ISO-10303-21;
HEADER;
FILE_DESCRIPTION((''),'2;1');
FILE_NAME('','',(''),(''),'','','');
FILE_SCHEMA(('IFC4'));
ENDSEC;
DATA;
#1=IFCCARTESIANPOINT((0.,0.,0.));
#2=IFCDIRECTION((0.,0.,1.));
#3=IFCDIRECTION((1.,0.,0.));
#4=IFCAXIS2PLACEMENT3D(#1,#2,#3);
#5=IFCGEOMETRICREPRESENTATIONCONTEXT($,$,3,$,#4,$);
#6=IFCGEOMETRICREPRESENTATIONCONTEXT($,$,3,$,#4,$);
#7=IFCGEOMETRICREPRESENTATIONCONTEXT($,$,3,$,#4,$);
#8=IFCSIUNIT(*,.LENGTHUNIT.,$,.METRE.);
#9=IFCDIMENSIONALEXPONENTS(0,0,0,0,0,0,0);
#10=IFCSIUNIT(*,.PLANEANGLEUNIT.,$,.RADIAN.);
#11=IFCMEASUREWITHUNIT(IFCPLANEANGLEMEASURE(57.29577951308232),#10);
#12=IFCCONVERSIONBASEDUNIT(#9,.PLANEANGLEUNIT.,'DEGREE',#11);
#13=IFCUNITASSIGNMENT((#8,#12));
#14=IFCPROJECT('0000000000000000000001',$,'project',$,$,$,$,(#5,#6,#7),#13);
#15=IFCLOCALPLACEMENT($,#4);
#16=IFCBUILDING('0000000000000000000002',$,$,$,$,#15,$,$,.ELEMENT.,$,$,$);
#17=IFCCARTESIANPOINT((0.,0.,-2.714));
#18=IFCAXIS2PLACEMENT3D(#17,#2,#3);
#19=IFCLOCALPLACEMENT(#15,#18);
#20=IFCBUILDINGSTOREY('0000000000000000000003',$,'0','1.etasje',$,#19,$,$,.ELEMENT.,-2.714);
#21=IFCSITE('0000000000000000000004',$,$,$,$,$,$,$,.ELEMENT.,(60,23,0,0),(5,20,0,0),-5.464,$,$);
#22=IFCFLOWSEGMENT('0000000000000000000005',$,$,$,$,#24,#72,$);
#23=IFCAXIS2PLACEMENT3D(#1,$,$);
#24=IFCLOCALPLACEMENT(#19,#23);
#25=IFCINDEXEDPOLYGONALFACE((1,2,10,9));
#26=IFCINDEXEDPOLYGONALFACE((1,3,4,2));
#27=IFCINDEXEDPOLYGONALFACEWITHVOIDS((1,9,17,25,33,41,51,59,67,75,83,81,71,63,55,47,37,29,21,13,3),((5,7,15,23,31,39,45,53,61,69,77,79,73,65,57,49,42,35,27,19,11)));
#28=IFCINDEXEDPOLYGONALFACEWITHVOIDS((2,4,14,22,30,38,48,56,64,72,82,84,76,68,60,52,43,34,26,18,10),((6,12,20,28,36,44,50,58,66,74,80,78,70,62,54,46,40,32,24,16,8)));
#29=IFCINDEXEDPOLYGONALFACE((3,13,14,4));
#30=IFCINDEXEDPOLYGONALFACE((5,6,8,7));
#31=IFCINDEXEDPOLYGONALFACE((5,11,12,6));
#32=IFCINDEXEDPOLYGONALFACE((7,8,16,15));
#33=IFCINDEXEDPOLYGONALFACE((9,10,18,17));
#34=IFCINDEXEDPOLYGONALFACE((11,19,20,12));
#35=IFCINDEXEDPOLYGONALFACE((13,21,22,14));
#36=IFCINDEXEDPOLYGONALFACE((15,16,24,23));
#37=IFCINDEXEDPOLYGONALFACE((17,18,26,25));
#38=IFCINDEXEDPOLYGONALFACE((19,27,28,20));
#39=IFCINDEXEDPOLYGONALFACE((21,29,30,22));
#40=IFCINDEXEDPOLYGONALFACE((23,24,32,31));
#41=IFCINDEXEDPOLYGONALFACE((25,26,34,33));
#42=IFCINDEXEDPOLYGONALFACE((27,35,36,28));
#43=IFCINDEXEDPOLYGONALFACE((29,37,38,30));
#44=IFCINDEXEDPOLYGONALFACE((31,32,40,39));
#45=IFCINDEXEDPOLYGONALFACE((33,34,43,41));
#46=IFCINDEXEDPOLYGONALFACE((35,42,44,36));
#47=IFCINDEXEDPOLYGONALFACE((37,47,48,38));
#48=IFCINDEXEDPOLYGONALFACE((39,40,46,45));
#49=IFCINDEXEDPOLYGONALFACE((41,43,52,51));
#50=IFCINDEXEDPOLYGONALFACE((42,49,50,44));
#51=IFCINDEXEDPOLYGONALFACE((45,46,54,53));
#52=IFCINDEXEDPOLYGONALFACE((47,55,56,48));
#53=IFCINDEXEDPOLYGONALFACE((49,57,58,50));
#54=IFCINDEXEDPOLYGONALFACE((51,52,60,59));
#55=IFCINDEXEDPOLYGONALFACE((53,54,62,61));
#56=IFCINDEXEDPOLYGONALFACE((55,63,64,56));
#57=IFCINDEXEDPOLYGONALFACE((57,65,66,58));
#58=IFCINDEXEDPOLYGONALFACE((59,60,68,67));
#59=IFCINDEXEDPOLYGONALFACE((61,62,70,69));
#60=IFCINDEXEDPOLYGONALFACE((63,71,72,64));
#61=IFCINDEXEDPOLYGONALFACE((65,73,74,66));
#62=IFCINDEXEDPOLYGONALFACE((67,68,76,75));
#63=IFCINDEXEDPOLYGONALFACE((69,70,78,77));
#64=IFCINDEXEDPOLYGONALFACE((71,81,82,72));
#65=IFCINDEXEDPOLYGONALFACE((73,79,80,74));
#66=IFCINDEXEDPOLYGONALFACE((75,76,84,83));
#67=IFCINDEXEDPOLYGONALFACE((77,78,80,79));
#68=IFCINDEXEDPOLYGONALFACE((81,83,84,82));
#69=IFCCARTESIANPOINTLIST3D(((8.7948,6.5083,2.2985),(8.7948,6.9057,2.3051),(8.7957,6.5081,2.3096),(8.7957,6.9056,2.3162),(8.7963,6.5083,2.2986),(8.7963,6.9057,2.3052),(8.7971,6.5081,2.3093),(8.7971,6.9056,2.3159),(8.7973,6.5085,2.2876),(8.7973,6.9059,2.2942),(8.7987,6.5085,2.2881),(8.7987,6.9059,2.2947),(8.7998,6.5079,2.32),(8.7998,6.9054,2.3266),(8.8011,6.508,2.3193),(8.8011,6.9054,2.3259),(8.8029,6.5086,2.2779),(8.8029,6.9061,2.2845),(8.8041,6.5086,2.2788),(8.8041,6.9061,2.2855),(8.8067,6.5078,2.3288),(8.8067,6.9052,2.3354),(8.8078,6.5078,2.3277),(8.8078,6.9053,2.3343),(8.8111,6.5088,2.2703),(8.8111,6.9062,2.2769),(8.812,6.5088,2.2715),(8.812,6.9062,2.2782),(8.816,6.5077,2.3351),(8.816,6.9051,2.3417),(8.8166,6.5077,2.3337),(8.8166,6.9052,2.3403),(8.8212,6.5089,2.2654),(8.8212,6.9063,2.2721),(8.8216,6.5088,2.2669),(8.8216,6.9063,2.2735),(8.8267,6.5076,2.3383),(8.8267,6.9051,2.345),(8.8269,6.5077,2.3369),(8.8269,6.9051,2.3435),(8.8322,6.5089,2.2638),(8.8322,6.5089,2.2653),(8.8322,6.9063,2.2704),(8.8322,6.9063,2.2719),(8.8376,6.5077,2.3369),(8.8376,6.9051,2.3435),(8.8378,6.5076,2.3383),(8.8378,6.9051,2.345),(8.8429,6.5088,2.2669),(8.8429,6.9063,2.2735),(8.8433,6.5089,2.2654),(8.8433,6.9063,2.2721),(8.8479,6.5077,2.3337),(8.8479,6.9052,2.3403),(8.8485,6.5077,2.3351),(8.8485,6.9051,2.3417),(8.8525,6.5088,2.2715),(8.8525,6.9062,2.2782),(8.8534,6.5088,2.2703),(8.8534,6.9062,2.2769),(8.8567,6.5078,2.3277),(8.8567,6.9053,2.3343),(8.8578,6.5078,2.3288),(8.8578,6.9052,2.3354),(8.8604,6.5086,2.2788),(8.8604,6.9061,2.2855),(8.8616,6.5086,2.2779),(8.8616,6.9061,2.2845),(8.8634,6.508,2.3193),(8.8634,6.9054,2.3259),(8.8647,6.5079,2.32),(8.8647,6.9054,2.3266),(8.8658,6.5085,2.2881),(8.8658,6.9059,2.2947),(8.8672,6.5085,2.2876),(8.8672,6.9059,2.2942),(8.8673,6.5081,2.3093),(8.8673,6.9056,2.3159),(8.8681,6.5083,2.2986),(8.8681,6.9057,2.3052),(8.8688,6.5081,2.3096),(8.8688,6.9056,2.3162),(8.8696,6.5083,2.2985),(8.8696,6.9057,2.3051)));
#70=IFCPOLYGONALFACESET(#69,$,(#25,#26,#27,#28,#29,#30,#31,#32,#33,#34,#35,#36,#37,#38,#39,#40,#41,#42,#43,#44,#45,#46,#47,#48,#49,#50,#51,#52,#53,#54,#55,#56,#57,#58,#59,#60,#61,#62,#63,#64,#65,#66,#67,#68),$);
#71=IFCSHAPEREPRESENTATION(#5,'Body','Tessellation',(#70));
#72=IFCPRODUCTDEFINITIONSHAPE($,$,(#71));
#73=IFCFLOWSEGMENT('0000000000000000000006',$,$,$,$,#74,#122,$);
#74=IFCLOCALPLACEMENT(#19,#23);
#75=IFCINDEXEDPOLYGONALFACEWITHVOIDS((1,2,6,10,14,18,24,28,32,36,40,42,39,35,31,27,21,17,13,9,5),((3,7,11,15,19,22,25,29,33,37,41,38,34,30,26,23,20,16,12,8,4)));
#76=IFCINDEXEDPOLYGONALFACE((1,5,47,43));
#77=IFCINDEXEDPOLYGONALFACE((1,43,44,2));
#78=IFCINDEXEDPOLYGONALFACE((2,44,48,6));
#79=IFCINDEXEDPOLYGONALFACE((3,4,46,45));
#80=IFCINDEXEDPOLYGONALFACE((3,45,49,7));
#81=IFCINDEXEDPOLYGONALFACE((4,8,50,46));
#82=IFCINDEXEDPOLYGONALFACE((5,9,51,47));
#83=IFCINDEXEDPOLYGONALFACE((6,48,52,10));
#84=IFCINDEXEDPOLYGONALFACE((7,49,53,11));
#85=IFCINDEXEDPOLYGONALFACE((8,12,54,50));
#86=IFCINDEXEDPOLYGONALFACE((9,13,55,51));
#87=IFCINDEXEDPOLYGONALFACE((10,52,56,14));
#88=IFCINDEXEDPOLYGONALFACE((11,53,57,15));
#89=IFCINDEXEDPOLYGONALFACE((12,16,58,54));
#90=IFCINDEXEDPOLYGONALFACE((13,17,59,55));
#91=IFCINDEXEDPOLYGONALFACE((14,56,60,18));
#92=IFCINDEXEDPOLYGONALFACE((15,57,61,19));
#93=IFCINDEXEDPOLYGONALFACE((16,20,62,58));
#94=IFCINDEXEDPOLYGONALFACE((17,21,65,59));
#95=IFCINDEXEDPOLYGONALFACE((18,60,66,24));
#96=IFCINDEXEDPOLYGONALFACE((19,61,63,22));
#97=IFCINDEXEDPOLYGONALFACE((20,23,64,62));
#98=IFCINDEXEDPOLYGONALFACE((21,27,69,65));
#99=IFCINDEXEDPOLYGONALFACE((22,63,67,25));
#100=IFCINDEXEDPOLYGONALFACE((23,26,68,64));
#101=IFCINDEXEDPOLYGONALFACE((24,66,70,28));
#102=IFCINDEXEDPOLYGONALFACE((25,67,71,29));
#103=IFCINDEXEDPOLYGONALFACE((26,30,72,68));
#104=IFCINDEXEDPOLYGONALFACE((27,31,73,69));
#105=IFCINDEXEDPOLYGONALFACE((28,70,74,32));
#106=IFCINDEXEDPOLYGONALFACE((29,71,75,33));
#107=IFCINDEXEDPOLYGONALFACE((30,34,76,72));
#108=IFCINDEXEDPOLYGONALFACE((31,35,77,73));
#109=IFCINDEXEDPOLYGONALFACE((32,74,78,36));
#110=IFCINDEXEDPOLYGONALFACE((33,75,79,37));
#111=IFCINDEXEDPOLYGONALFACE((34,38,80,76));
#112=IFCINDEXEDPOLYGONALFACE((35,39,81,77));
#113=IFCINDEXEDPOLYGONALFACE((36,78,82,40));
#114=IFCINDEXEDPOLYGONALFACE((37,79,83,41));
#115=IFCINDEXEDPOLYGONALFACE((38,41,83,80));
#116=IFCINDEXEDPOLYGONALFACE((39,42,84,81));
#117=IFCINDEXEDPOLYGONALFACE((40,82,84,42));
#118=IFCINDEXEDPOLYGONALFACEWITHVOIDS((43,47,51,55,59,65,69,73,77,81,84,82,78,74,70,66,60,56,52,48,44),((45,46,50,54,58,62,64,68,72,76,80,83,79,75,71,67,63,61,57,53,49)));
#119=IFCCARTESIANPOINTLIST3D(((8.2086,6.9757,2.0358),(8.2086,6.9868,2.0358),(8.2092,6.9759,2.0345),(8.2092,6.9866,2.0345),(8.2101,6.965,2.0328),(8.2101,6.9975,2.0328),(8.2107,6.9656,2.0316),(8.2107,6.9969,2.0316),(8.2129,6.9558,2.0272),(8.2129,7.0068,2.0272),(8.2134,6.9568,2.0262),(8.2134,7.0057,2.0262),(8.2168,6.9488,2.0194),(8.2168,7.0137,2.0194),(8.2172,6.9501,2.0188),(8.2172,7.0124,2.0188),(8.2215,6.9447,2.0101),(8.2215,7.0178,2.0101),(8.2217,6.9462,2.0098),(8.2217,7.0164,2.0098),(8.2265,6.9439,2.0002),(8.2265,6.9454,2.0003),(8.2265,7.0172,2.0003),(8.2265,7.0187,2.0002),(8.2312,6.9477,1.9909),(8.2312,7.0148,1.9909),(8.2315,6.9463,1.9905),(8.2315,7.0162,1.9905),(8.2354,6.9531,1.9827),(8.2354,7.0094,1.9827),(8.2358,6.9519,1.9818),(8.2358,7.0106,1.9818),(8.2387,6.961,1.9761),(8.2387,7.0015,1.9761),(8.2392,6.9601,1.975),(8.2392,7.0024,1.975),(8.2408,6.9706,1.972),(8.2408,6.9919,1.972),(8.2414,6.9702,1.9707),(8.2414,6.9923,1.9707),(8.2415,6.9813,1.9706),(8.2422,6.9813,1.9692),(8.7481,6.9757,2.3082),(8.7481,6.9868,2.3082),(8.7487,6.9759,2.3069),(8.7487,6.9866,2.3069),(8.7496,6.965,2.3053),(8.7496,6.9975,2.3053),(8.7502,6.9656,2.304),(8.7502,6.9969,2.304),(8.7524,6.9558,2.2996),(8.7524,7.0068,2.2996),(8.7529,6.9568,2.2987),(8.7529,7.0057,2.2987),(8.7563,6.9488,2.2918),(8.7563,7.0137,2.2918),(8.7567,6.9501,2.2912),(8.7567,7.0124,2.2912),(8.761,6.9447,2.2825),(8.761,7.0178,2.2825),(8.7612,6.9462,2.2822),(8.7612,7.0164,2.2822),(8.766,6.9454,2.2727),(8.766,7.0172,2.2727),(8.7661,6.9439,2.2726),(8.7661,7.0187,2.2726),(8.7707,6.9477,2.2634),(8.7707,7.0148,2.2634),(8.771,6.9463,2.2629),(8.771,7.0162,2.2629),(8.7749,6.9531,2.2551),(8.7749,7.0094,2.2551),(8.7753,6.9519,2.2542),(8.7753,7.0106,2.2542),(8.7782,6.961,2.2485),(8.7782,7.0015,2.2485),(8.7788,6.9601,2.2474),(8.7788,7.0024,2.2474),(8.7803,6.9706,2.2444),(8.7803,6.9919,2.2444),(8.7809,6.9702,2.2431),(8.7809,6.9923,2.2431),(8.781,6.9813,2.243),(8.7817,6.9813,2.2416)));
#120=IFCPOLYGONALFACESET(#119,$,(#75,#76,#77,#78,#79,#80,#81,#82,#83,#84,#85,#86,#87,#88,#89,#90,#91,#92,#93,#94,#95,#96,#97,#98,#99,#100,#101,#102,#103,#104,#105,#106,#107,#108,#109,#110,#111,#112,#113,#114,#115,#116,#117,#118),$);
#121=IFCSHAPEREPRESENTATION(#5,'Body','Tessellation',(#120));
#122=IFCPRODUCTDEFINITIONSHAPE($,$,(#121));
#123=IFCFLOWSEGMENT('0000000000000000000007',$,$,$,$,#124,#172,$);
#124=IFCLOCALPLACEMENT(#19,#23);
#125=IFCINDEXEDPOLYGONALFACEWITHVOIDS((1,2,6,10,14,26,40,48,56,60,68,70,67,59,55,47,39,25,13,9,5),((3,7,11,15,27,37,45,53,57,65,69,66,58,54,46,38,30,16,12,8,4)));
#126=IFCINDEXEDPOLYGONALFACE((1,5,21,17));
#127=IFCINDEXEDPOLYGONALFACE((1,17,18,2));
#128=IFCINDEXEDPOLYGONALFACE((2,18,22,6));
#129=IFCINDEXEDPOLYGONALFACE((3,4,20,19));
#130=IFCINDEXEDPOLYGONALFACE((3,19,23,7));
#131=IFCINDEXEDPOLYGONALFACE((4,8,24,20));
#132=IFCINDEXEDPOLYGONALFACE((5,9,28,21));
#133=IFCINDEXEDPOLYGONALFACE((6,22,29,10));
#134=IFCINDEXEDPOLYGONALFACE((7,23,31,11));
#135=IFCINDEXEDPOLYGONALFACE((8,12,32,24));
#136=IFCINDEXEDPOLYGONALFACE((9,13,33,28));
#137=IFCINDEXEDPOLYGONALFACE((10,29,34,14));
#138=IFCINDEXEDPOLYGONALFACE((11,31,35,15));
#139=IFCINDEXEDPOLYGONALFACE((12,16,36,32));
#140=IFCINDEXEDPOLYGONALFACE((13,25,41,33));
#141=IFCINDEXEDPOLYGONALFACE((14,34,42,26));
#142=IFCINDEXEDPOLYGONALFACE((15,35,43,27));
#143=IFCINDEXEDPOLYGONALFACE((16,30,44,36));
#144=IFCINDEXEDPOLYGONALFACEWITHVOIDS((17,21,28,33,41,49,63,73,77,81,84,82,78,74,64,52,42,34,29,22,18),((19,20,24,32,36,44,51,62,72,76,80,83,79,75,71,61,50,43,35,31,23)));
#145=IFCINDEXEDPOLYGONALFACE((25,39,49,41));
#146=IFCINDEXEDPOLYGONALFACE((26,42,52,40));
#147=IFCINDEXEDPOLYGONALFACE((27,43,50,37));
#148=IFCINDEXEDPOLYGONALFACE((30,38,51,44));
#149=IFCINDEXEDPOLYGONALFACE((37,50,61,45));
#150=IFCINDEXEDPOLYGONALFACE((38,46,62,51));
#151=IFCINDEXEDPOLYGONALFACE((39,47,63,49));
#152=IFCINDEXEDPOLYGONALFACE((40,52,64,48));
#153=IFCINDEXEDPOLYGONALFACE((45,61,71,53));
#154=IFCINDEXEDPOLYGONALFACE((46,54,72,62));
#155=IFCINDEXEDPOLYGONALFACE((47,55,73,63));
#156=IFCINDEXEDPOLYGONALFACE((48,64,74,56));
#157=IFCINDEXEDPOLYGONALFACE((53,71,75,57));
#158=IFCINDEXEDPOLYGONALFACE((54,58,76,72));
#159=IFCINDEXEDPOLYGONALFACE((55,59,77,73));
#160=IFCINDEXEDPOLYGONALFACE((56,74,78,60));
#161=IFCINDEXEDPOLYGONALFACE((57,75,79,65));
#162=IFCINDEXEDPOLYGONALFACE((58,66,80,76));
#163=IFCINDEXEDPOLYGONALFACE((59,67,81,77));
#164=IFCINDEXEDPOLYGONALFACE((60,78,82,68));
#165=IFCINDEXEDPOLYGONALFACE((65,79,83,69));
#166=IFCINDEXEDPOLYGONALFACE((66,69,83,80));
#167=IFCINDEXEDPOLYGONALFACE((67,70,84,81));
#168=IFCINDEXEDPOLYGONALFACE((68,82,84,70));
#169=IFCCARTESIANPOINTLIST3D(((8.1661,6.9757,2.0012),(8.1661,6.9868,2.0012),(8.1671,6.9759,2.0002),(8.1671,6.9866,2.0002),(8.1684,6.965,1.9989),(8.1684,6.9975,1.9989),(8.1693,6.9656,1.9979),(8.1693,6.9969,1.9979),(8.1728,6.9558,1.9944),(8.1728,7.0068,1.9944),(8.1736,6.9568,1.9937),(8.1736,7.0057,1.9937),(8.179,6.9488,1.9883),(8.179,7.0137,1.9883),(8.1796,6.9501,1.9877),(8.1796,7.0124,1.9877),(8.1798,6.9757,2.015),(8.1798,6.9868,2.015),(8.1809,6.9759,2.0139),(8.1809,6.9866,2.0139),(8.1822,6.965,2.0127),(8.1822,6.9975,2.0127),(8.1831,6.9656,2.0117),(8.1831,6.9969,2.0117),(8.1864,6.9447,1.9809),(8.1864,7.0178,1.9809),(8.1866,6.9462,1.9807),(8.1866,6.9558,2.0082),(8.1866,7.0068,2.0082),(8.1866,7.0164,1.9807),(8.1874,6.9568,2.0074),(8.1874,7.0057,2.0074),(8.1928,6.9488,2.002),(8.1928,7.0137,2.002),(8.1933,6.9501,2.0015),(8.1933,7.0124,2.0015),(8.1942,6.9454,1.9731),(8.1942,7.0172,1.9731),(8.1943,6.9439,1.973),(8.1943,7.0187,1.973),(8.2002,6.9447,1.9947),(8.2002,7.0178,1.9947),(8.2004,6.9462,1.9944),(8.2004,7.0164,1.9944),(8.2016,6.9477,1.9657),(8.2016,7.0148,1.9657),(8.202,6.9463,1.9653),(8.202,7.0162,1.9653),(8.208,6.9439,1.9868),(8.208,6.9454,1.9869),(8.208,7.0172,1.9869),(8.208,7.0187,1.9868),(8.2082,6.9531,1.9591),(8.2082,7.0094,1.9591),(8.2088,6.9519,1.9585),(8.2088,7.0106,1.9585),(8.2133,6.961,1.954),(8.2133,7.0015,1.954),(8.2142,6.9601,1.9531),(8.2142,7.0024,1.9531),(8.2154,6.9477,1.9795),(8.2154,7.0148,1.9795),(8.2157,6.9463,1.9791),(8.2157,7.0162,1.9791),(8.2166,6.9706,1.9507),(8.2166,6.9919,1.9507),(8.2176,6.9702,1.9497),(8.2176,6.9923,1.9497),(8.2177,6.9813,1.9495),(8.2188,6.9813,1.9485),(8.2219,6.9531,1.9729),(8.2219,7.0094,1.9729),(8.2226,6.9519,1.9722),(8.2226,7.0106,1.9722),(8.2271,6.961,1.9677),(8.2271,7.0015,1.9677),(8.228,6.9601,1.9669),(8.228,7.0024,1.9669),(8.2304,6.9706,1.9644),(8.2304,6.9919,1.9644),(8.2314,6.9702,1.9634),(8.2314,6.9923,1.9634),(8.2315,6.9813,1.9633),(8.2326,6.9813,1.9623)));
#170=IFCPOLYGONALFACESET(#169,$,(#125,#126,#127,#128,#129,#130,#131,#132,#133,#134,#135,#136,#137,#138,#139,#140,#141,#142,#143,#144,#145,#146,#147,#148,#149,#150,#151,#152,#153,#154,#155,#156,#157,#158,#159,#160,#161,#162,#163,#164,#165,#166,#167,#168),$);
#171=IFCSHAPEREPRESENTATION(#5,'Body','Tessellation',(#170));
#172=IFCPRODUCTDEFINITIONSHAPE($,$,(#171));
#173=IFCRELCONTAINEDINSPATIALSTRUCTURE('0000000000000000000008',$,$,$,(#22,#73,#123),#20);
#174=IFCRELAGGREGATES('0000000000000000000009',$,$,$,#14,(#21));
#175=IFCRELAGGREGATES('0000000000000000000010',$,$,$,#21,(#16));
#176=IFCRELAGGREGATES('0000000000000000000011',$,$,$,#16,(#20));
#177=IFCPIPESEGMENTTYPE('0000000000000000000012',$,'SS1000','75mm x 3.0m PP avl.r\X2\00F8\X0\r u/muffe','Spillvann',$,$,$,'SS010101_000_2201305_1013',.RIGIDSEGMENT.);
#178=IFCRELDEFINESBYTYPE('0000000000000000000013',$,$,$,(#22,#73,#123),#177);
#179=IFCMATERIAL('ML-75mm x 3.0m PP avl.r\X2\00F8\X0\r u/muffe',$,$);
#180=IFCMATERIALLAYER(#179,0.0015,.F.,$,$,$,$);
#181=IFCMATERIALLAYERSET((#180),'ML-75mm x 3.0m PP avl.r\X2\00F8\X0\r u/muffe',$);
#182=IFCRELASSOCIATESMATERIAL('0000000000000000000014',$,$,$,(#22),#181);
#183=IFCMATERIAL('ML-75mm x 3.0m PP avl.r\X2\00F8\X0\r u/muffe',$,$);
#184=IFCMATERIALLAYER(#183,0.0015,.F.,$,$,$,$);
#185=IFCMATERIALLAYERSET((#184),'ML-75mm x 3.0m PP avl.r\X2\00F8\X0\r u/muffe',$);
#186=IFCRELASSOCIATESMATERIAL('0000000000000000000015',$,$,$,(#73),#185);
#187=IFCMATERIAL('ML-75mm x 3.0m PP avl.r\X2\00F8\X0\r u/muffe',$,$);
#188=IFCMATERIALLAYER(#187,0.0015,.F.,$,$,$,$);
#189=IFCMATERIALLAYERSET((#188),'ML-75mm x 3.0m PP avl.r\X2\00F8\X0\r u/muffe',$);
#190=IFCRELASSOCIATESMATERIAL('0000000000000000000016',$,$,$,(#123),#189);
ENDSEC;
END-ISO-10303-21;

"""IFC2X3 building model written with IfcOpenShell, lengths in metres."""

from ifc_helpers import new_model, entity, si_unit, converted_unit, frame, origin_with_axes, origin_2d_with_axis, place, context, project, spatial, hollow_circle, extrude, material, layer, layer_set, layer_usage, type_object, element, save


model = new_model("IFC2X3")

# Units and contexts
context_of_model_1 = context(None, 3, world=origin_with_axes())
context_of_model_2 = context(None, 3, world=origin_with_axes())
context_of_model_3 = context(None, 3, world=origin_with_axes())
ifc_project = project(units=[si_unit("LENGTHUNIT", "METRE"), converted_unit("PLANEANGLEUNIT", "DEGREE", entity("IfcPlaneAngleMeasure", 57.29577951308232), si_unit("PLANEANGLEUNIT", "RADIAN"), dimensions=[0, 0, 0, 0, 0, 0, 0])], contexts=[context_of_model_1, context_of_model_2, context_of_model_3])

# Site, building, storey
site = spatial("IfcSite", under=ifc_project, CompositionType="ELEMENT", RefLatitude=(60, 23, 0, 0), RefLongitude=(5, 20, 0, 0), RefElevation=-5.464)
building_placement = place(None, origin_with_axes())
building = spatial("IfcBuilding", under=site, at=building_placement, CompositionType="ELEMENT")
storey_placement = place(building_placement, frame((0.0, 0.0, -2.714), z_axis=(0.0, 0.0, 1.0), x_axis=(1.0, 0.0, 0.0)))
storey = spatial("IfcBuildingStorey", under=building, at=storey_placement, Name="0", Description="1.etasje", CompositionType="ELEMENT", Elevation=-2.714)

# Flow segments
pipe_segment_type_1 = type_object("IfcPipeSegmentType", Name="SS1000", Description="75mm x 3.0m PP avl.rør u/muffe", ApplicableOccurrence="Spillvann", ElementType="SS010101_000_2201305_1013", PredefinedType="RIGIDSEGMENT")
ifc_material_1 = material(Name="ML-75mm x 3.0m PP avl.rør u/muffe")
ifc_layer_1 = layer(ifc_material_1, 0.0015, ventilated=False)
ifc_layer_set_1 = layer_set([ifc_layer_1], Name="ML-75mm x 3.0m PP avl.rør u/muffe")
ifc_layer_usage_1 = layer_usage(ifc_layer_set_1, "AXIS2", "POSITIVE", 0.0)
flow_segment_1_placement = place(storey_placement, frame((8.8322, 6.5083, 2.3013), z_axis=(0.0, 0.999861, 0.016665), x_axis=(0.0, 0.016665, -0.999861)))
element("IfcFlowSegment", 1, at=flow_segment_1_placement, inside=storey, type_object=pipe_segment_type_1, material=ifc_layer_usage_1, context=context_of_model_1, shape_type="SweptSolid", body=[
    extrude(hollow_circle(Radius=0.0375, WallThickness=0.0015, at=origin_2d_with_axis()), origin_with_axes(), (0.0, 0.0, 1.0), 0.3975),
])
ifc_material_2 = material(Name="ML-75mm x 3.0m PP avl.rør u/muffe")
ifc_layer_2 = layer(ifc_material_2, 0.0015, ventilated=False)
ifc_layer_set_2 = layer_set([ifc_layer_2], Name="ML-75mm x 3.0m PP avl.rør u/muffe")
ifc_layer_usage_2 = layer_usage(ifc_layer_set_2, "AXIS2", "POSITIVE", 0.0)
flow_segment_2_placement = place(storey_placement, frame((8.7648, 6.9813, 2.2751), z_axis=(-0.892665, 0.0, -0.45072), x_axis=(0.45072, 0.0, -0.892665)))
element("IfcFlowSegment", 2, at=flow_segment_2_placement, inside=storey, type_object=pipe_segment_type_1, material=ifc_layer_usage_2, context=context_of_model_1, shape_type="SweptSolid", body=[
    extrude(hollow_circle(Radius=0.0375, WallThickness=0.0015, at=origin_2d_with_axis()), origin_with_axes(), (0.0, 0.0, 1.0), 0.6044),
])
ifc_material_3 = material(Name="ML-75mm x 3.0m PP avl.rør u/muffe")
ifc_layer_3 = layer(ifc_material_3, 0.0015, ventilated=False)
ifc_layer_set_3 = layer_set([ifc_layer_3], Name="ML-75mm x 3.0m PP avl.rør u/muffe")
ifc_layer_usage_3 = layer_usage(ifc_layer_set_3, "AXIS2", "POSITIVE", 0.0)
flow_segment_3_placement = place(storey_placement, frame((8.2061, 6.9813, 1.9888), z_axis=(-0.707107, 0.0, -0.707107), x_axis=(0.707107, 0.0, -0.707107)))
element("IfcFlowSegment", 3, at=flow_segment_3_placement, inside=storey, type_object=pipe_segment_type_1, material=ifc_layer_usage_3, context=context_of_model_1, shape_type="SweptSolid", body=[
    extrude(hollow_circle(Radius=0.0375, WallThickness=0.0015, at=origin_2d_with_axis()), origin_with_axes(), (0.0, 0.0, 1.0), 0.0195),
])

save(model, "model.ifc")
